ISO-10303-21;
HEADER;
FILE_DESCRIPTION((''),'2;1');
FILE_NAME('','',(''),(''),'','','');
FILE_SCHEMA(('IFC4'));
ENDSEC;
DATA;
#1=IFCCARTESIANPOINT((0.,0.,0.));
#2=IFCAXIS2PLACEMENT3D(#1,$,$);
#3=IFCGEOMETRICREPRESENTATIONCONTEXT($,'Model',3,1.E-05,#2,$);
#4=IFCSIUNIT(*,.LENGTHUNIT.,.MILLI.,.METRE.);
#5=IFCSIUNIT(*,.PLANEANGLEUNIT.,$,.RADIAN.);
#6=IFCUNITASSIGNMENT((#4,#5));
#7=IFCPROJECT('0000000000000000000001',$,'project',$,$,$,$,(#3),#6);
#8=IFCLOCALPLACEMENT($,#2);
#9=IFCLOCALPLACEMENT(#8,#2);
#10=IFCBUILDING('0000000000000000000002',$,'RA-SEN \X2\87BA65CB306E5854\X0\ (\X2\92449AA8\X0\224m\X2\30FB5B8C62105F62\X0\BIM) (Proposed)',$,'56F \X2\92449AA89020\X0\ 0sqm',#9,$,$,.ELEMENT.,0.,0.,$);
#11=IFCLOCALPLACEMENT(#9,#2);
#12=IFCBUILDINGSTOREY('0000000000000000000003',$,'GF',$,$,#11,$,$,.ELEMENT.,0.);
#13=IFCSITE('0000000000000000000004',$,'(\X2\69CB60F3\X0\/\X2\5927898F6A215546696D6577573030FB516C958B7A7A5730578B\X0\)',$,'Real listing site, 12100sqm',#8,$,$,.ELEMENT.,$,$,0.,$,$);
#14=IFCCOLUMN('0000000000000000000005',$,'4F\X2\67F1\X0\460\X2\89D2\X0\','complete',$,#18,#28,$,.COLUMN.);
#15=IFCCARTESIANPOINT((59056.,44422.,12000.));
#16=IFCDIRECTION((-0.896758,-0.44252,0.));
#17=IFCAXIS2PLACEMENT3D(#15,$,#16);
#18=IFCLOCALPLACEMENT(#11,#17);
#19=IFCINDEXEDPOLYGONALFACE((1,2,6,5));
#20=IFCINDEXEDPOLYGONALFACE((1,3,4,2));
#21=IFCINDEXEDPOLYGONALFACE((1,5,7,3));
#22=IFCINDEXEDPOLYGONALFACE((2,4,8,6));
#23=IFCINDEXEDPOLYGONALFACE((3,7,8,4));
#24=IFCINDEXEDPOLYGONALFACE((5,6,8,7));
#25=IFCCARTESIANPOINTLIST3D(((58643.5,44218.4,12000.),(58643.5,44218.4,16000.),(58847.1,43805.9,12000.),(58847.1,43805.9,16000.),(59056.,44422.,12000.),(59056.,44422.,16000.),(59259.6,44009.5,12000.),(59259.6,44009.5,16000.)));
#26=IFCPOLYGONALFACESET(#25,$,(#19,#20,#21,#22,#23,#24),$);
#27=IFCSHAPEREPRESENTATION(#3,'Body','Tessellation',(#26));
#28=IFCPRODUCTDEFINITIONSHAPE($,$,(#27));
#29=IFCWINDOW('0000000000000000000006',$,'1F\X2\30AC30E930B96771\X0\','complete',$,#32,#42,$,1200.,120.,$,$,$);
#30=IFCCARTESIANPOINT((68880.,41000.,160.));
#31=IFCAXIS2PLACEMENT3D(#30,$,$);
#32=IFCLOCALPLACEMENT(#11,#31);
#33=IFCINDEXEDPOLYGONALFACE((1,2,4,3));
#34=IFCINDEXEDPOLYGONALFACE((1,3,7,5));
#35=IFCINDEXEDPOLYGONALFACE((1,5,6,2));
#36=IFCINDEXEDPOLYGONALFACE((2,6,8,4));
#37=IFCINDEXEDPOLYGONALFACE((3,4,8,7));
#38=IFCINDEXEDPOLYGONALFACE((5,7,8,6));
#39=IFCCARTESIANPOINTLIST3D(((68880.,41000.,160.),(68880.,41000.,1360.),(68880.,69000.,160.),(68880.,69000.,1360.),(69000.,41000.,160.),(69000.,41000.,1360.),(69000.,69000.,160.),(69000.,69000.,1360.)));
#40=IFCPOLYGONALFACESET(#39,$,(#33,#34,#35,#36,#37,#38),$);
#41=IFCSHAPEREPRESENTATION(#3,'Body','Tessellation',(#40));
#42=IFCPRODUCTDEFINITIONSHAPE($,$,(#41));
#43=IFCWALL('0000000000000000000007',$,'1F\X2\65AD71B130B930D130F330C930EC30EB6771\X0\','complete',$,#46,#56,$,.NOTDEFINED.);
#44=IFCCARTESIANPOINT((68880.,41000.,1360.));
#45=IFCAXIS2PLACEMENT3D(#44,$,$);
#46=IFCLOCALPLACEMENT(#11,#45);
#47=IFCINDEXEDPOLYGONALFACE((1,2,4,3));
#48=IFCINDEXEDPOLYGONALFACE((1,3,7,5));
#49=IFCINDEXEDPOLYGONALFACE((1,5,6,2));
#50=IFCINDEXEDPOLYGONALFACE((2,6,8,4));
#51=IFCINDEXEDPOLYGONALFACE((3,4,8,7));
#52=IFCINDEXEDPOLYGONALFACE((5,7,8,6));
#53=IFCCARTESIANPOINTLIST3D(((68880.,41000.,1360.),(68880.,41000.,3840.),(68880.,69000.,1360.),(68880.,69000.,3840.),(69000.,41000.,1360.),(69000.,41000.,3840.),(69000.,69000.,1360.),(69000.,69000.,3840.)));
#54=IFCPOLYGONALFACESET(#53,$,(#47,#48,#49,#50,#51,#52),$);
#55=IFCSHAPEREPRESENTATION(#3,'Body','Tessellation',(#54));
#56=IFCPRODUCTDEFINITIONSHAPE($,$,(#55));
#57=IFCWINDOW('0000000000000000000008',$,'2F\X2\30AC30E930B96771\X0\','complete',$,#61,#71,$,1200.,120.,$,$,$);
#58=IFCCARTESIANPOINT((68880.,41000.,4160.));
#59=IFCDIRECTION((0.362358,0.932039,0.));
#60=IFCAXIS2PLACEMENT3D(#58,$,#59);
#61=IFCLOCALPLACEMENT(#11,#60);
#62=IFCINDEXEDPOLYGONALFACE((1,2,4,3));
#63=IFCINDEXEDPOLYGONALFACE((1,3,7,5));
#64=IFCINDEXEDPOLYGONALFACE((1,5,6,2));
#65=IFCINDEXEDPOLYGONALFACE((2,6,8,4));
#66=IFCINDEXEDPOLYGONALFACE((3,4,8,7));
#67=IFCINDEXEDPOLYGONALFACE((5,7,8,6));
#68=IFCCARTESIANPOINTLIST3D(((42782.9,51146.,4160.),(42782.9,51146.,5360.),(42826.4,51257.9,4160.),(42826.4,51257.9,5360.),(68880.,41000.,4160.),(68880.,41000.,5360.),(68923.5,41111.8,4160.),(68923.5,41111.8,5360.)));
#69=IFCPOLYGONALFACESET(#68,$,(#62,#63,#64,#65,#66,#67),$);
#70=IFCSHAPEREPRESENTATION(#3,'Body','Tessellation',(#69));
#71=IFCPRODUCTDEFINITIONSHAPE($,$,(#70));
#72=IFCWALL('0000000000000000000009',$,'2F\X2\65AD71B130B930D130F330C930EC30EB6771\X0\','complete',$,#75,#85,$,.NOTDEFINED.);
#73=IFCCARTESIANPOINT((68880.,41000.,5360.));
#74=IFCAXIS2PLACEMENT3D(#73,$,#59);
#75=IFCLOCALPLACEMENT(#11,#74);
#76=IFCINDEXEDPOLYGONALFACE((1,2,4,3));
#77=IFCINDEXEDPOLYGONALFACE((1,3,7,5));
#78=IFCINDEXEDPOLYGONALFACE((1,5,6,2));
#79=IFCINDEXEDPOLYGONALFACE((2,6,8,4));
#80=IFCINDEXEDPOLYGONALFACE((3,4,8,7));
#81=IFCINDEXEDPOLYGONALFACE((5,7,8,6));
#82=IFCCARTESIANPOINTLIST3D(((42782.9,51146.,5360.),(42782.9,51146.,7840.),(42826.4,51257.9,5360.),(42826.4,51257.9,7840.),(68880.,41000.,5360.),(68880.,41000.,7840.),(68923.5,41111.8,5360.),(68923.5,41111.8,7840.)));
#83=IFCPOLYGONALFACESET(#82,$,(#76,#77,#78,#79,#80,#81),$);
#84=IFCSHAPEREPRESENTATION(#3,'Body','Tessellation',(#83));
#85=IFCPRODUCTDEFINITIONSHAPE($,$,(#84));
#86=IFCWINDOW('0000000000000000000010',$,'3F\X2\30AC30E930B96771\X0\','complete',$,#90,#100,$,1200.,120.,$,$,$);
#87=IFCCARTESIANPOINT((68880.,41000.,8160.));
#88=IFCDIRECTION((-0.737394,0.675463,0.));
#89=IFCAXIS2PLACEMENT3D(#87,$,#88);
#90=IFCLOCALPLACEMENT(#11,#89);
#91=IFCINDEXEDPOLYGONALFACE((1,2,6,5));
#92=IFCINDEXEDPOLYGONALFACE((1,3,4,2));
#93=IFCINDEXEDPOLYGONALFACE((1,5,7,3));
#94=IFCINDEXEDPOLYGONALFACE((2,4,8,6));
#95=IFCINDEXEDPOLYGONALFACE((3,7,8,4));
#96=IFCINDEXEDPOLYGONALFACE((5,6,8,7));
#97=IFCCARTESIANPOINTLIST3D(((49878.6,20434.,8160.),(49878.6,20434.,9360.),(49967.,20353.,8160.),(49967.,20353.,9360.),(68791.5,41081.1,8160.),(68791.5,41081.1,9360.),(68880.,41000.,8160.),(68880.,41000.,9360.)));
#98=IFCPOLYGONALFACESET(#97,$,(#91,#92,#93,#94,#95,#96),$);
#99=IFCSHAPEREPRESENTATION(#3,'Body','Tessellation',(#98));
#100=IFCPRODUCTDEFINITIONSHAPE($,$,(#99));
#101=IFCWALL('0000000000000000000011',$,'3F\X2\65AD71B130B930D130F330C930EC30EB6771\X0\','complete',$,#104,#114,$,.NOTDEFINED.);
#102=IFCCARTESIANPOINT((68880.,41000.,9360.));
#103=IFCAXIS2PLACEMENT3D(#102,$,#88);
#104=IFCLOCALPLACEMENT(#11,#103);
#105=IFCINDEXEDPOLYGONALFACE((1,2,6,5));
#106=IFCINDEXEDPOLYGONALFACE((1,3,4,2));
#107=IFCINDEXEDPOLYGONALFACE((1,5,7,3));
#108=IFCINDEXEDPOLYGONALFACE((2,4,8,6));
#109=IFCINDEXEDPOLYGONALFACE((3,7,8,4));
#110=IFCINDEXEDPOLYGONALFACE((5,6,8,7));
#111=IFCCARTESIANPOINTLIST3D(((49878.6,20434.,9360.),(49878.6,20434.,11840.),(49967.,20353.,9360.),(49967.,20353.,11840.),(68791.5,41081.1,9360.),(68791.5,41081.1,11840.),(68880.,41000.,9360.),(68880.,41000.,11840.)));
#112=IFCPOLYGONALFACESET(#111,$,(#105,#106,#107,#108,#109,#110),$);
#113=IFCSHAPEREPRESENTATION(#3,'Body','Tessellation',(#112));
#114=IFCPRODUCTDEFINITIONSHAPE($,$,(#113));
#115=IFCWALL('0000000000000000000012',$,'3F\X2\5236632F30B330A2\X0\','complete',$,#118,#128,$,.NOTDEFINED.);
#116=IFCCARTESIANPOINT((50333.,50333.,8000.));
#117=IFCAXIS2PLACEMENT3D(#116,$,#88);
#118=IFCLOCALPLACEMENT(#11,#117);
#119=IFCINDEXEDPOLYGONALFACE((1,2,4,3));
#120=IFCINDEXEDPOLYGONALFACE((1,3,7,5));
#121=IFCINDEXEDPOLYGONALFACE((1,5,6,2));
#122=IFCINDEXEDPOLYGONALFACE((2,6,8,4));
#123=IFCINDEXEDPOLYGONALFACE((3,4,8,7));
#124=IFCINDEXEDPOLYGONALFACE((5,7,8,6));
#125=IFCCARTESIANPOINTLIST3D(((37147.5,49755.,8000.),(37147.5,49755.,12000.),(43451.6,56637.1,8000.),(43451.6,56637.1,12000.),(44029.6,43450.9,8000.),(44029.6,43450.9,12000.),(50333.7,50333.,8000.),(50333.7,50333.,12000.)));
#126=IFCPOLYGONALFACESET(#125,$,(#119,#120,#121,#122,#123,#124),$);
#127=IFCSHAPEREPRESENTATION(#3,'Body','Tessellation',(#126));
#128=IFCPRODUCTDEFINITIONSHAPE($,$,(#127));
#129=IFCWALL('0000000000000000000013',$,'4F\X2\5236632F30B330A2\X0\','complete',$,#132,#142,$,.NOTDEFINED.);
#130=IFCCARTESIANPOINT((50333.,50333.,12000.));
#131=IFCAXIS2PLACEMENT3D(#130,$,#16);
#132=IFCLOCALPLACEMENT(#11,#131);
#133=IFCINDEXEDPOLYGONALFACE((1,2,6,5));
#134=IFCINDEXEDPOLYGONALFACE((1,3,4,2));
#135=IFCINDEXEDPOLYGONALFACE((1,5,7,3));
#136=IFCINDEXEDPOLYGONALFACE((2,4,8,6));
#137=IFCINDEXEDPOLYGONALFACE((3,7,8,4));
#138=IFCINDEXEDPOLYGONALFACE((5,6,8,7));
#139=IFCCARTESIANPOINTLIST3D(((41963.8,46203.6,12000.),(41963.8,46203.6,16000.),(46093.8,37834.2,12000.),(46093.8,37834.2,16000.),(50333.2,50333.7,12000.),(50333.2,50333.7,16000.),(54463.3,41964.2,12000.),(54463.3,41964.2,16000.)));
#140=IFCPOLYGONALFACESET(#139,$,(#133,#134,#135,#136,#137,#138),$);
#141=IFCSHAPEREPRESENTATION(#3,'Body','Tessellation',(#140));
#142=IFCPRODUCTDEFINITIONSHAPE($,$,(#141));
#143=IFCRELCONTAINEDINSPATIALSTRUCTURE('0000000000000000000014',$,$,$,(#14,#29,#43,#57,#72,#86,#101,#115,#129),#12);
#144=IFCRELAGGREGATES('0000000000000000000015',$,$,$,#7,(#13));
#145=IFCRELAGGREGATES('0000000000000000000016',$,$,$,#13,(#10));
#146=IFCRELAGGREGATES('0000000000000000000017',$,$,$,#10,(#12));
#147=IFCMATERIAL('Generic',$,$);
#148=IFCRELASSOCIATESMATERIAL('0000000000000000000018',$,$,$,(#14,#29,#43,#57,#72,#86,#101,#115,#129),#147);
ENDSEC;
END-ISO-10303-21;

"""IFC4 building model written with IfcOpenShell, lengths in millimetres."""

from ifc_helpers import new_model, si_unit, frame, frame_2d, origin, place, context, project, spatial, rectangle, extrude, material, element, save


model = new_model("IFC4")

# Units and contexts
model_context = context("Model", 3, precision=1e-05, world=origin())
ifc_project = project(units=[si_unit("LENGTHUNIT", "METRE", prefix="MILLI"), si_unit("PLANEANGLEUNIT", "RADIAN")], contexts=[model_context])

# Site, building, storey
site_placement = place(None, origin())
site = spatial("IfcSite", under=ifc_project, at=site_placement, Name="(構想/大規模商業敷地・公開空地型)", ObjectType="Real listing site, 12100sqm", CompositionType="ELEMENT", RefElevation=0.0)
building_placement = place(site_placement, origin())
building = spatial("IfcBuilding", under=site, at=building_placement, Name="RA-SEN 螺旋の塔 (鉄骨224m・完成形BIM) (Proposed)", ObjectType="56F 鉄骨造 0sqm", CompositionType="ELEMENT", ElevationOfRefHeight=0.0, ElevationOfTerrain=0.0)
storey_placement = place(building_placement, origin())
storey = spatial("IfcBuildingStorey", under=building, at=storey_placement, Name="GF", CompositionType="ELEMENT", Elevation=0.0)

# Column
ifc_material = material(Name="Generic")
column_1_placement = place(storey_placement, frame((59056.0, 44422.0, 12000.0), x_axis=(-0.896758, -0.44252, 0.0)))
element("IfcColumn", 1, at=column_1_placement, inside=storey, material=ifc_material, Name="4F柱460角", Description="complete", PredefinedType="COLUMN", context=model_context, shape_type="SweptSolid", body=[
    extrude(rectangle(XDim=460.0, YDim=460.0, at=frame_2d((230.0, 230.0))), frame((59056.0, 44422.0, 12000.0), x_axis=(-0.896758, -0.44252, 0.0)), (0.0, 0.0, 1.0), 4000.0),
])

# Window
window_1_placement = place(storey_placement, frame((68880.0, 41000.0, 160.0)))
element("IfcWindow", 2, at=window_1_placement, inside=storey, material=ifc_material, Name="1Fガラス東", Description="complete", OverallHeight=1200.0, OverallWidth=120.0, context=model_context, shape_type="SweptSolid", body=[
    extrude(rectangle(XDim=120.0, YDim=28000.0, at=frame_2d((60.0, 14000.0))), frame((68880.0, 41000.0, 160.0)), (0.0, 0.0, 1.0), 1200.0),
])

# Wall
wall_1_placement = place(storey_placement, frame((68880.0, 41000.0, 1360.0)))
element("IfcWall", 3, at=wall_1_placement, inside=storey, material=ifc_material, Name="1F断熱スパンドレル東", Description="complete", PredefinedType="NOTDEFINED", context=model_context, shape_type="SweptSolid", body=[
    extrude(rectangle(XDim=120.0, YDim=28000.0, at=frame_2d((60.0, 14000.0))), frame((68880.0, 41000.0, 1360.0)), (0.0, 0.0, 1.0), 2480.0),
])

# Window
window_2_placement = place(storey_placement, frame((68880.0, 41000.0, 4160.0), x_axis=(0.362358, 0.932039, 0.0)))
element("IfcWindow", 4, at=window_2_placement, inside=storey, material=ifc_material, Name="2Fガラス東", Description="complete", OverallHeight=1200.0, OverallWidth=120.0, context=model_context, shape_type="SweptSolid", body=[
    extrude(rectangle(XDim=120.0, YDim=28000.0, at=frame_2d((60.0, 14000.0))), frame((68880.0, 41000.0, 4160.0), x_axis=(0.362358, 0.932039, 0.0)), (0.0, 0.0, 1.0), 1200.0),
])

# Wall
wall_2_placement = place(storey_placement, frame((68880.0, 41000.0, 5360.0), x_axis=(0.362358, 0.932039, 0.0)))
element("IfcWall", 5, at=wall_2_placement, inside=storey, material=ifc_material, Name="2F断熱スパンドレル東", Description="complete", PredefinedType="NOTDEFINED", context=model_context, shape_type="SweptSolid", body=[
    extrude(rectangle(XDim=120.0, YDim=28000.0, at=frame_2d((60.0, 14000.0))), frame((68880.0, 41000.0, 5360.0), x_axis=(0.362358, 0.932039, 0.0)), (0.0, 0.0, 1.0), 2480.0),
])

# Window
window_3_placement = place(storey_placement, frame((68880.0, 41000.0, 8160.0), x_axis=(-0.737394, 0.675463, 0.0)))
element("IfcWindow", 6, at=window_3_placement, inside=storey, material=ifc_material, Name="3Fガラス東", Description="complete", OverallHeight=1200.0, OverallWidth=120.0, context=model_context, shape_type="SweptSolid", body=[
    extrude(rectangle(XDim=120.0, YDim=28000.0, at=frame_2d((60.0, 14000.0))), frame((68880.0, 41000.0, 8160.0), x_axis=(-0.737394, 0.675463, 0.0)), (0.0, 0.0, 1.0), 1200.0),
])

# Walls
wall_3_placement = place(storey_placement, frame((68880.0, 41000.0, 9360.0), x_axis=(-0.737394, 0.675463, 0.0)))
element("IfcWall", 7, at=wall_3_placement, inside=storey, material=ifc_material, Name="3F断熱スパンドレル東", Description="complete", PredefinedType="NOTDEFINED", context=model_context, shape_type="SweptSolid", body=[
    extrude(rectangle(XDim=120.0, YDim=28000.0, at=frame_2d((60.0, 14000.0))), frame((68880.0, 41000.0, 9360.0), x_axis=(-0.737394, 0.675463, 0.0)), (0.0, 0.0, 1.0), 2480.0),
])
wall_4_placement = place(storey_placement, frame((50333.0, 50333.0, 8000.0), x_axis=(-0.737394, 0.675463, 0.0)))
element("IfcWall", 8, at=wall_4_placement, inside=storey, material=ifc_material, Name="3F制振コア", Description="complete", PredefinedType="NOTDEFINED", context=model_context, shape_type="SweptSolid", body=[
    extrude(rectangle(XDim=9333.0, YDim=9333.0, at=frame_2d((4666.0, 4666.0))), frame((50333.0, 50333.0, 8000.0), x_axis=(-0.737394, 0.675463, 0.0)), (0.0, 0.0, 1.0), 4000.0),
])
wall_5_placement = place(storey_placement, frame((50333.0, 50333.0, 12000.0), x_axis=(-0.896758, -0.44252, 0.0)))
element("IfcWall", 9, at=wall_5_placement, inside=storey, material=ifc_material, Name="4F制振コア", Description="complete", PredefinedType="NOTDEFINED", context=model_context, shape_type="SweptSolid", body=[
    extrude(rectangle(XDim=9333.0, YDim=9333.0, at=frame_2d((4666.0, 4666.0))), frame((50333.0, 50333.0, 12000.0), x_axis=(-0.896758, -0.44252, 0.0)), (0.0, 0.0, 1.0), 4000.0),
])

save(model, "model.ifc")
